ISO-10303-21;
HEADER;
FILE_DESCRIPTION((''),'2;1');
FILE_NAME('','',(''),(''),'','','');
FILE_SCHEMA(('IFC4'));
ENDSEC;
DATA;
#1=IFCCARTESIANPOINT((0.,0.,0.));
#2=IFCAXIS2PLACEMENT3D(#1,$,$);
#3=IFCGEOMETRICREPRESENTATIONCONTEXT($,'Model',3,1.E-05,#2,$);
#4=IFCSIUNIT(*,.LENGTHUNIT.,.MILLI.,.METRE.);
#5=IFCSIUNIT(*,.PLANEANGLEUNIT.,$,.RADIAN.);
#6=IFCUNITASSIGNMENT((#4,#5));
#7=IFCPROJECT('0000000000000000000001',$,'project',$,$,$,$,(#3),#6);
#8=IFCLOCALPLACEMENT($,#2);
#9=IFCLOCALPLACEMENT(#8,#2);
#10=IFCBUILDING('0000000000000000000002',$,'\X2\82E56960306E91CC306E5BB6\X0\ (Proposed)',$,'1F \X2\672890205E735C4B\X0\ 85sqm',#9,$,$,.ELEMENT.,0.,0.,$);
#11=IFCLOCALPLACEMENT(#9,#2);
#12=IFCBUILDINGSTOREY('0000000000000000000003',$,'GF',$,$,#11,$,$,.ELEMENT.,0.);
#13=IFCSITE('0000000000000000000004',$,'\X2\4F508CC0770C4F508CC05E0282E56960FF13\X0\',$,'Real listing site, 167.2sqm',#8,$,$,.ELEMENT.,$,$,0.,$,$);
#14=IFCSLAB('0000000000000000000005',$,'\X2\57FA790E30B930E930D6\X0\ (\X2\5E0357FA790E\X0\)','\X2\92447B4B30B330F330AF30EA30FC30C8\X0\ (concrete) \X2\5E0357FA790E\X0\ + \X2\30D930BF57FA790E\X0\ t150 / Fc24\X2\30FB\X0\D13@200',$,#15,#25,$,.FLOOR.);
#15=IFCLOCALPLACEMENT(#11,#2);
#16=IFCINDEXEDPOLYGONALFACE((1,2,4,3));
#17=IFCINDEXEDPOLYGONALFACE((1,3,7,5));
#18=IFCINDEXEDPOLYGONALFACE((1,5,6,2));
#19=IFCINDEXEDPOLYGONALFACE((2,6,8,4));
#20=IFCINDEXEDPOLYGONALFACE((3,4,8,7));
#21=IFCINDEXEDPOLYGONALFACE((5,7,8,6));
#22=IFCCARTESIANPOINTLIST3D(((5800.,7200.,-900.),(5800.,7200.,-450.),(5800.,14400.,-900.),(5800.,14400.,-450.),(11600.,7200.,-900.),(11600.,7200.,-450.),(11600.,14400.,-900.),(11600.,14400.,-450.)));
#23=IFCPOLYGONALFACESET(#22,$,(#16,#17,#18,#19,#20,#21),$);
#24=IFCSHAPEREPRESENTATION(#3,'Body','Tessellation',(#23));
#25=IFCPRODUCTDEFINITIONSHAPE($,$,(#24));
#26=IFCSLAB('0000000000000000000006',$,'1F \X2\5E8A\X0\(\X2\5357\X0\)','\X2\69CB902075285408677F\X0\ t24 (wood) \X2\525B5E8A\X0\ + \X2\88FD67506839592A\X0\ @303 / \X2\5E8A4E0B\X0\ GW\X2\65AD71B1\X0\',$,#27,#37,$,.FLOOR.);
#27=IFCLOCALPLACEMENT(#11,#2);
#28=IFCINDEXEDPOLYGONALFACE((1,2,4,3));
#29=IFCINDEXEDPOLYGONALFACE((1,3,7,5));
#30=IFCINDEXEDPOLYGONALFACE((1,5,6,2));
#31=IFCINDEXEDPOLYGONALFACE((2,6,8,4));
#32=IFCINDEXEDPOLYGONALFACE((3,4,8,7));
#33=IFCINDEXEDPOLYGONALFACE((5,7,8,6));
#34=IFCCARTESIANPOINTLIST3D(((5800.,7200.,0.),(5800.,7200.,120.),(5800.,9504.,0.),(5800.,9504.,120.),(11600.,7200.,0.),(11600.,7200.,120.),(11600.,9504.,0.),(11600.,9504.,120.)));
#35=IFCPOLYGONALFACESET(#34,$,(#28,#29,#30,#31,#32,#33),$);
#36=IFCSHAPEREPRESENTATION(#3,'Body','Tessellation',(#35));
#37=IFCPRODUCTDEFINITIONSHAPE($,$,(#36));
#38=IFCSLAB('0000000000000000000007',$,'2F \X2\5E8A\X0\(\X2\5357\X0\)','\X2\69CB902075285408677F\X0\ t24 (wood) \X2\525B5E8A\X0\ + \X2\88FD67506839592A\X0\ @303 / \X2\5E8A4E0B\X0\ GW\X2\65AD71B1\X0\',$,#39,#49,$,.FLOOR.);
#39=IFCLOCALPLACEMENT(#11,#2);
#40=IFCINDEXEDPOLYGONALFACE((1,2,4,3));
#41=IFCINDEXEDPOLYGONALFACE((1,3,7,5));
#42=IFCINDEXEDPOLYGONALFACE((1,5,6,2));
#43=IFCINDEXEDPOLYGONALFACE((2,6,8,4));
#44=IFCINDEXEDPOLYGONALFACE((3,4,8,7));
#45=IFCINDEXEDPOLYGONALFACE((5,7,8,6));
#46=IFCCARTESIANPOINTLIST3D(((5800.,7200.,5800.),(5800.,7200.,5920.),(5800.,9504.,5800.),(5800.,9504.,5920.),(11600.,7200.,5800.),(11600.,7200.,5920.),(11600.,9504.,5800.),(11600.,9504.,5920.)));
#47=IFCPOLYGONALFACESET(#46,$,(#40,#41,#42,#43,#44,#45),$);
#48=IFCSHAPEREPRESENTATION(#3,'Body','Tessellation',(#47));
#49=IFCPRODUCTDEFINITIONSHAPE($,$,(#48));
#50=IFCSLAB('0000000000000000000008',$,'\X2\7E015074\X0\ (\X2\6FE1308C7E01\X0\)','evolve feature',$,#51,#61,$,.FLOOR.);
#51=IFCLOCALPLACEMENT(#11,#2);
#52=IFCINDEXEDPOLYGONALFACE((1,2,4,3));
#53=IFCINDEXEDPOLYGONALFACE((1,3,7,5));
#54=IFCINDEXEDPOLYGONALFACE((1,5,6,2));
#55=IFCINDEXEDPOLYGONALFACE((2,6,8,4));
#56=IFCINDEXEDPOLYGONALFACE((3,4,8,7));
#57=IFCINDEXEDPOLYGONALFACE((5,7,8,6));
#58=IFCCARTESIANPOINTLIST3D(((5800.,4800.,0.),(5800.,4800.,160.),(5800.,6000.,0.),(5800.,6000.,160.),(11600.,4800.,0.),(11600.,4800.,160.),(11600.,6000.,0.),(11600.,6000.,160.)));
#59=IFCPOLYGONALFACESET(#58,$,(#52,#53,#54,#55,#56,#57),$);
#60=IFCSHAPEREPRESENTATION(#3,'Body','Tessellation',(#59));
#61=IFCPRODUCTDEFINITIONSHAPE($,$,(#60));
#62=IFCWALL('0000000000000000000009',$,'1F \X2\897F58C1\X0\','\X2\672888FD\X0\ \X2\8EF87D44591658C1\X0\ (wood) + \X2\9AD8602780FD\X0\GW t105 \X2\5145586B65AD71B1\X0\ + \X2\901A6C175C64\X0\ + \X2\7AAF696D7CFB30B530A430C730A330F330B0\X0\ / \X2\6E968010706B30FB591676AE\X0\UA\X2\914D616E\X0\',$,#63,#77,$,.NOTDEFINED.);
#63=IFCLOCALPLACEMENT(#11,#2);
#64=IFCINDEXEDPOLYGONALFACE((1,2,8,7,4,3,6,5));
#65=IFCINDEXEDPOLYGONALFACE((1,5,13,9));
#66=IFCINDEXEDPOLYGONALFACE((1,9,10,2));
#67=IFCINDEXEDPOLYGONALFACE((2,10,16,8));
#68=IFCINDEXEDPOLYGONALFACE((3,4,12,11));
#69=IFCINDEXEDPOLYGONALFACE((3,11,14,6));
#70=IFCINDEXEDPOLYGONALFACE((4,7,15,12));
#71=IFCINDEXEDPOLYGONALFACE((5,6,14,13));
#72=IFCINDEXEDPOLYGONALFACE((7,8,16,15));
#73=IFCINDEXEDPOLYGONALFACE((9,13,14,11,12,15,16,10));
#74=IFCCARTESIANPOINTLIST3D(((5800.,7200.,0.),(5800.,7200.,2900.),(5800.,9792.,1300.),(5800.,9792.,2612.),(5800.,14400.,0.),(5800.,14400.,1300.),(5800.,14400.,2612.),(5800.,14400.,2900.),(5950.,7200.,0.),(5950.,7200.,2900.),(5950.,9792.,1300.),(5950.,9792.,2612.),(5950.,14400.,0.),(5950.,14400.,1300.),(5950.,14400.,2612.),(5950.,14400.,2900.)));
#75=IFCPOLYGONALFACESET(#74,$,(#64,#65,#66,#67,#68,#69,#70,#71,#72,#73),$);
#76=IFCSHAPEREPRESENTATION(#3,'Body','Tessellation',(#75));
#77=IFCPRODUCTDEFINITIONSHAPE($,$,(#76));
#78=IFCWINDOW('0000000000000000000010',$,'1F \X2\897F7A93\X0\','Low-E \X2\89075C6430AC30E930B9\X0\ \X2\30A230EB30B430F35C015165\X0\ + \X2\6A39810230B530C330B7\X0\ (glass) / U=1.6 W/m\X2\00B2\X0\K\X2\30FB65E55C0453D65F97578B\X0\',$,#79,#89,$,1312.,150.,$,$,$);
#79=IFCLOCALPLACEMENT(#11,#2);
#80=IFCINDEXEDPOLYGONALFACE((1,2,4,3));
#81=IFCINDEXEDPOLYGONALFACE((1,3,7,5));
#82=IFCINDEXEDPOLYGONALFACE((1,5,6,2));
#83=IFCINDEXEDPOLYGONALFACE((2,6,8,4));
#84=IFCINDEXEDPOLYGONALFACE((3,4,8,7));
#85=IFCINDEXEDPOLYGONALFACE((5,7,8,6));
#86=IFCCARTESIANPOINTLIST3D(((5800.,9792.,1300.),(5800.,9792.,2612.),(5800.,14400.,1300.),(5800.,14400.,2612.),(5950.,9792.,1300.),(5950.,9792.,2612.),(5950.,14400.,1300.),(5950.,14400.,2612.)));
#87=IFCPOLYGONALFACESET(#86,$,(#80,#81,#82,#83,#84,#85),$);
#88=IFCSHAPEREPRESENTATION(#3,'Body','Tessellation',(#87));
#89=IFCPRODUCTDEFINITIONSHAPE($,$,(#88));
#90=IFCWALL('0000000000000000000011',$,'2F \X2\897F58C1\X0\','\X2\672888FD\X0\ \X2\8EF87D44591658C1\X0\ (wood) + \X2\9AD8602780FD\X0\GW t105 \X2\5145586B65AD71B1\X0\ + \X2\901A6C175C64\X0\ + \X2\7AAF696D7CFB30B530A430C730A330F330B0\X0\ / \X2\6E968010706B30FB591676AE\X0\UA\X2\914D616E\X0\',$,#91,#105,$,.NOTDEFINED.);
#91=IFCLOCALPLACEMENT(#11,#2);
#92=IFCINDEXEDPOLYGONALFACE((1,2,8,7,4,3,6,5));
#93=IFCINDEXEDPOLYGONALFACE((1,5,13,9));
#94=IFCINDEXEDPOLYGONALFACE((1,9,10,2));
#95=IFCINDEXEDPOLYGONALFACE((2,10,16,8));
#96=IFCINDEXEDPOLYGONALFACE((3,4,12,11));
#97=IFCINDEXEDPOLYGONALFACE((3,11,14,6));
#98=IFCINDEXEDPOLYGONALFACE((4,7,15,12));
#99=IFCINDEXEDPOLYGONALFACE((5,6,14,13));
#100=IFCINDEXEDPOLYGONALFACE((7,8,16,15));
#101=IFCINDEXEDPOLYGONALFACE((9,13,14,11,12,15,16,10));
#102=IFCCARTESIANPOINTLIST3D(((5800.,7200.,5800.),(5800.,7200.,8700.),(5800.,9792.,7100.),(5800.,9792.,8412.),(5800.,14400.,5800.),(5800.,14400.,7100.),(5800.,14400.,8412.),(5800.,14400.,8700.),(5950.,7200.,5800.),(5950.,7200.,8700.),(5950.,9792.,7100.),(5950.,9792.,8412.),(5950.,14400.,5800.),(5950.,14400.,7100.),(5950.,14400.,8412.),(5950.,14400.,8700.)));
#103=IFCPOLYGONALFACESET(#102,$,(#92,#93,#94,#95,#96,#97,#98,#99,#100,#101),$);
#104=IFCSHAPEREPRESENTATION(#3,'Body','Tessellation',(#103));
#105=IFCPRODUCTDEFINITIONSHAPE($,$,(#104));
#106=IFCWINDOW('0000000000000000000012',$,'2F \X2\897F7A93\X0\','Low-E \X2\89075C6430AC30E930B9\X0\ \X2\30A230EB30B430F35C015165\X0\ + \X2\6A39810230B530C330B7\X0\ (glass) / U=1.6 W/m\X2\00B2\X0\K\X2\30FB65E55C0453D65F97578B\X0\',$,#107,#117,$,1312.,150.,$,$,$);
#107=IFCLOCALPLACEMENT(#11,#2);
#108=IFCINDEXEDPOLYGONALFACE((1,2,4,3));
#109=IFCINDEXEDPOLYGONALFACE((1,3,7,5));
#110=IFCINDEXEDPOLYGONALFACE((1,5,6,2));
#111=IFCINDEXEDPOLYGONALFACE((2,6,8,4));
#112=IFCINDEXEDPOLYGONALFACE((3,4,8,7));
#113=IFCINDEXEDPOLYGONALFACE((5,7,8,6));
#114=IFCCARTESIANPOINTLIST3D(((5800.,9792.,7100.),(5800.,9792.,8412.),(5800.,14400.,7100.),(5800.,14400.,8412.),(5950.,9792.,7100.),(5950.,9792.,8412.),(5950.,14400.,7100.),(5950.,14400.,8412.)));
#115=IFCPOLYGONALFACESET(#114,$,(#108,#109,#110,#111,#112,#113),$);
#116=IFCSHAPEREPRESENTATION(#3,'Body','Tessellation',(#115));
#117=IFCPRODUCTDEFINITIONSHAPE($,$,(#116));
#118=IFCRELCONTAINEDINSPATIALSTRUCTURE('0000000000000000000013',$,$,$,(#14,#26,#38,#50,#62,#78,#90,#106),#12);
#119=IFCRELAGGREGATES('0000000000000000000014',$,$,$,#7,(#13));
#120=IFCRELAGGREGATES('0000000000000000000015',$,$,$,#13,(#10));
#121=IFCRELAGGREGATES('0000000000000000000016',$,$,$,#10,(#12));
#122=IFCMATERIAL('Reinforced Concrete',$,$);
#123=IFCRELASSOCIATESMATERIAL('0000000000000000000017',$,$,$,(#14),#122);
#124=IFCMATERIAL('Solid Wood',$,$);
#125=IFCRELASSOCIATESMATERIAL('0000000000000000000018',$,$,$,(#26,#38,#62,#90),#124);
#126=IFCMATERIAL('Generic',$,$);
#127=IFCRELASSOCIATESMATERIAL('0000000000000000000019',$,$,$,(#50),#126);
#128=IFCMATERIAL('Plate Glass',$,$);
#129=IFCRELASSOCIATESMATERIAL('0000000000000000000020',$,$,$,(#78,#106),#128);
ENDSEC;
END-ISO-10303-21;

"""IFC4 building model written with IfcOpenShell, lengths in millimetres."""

from ifc_helpers import new_model, si_unit, frame, frame_2d, origin, place, context, project, spatial, rectangle, extrude, material, element, fill, save


model = new_model("IFC4")

# Units and contexts
model_context = context("Model", 3, precision=1e-05, world=origin())
ifc_project = project(units=[si_unit("LENGTHUNIT", "METRE", prefix="MILLI"), si_unit("PLANEANGLEUNIT", "RADIAN")], contexts=[model_context])

# Site, building, storey
site_placement = place(None, origin())
site = spatial("IfcSite", under=ifc_project, at=site_placement, Name="佐賀県佐賀市若楠３", ObjectType="Real listing site, 167.2sqm", CompositionType="ELEMENT", RefElevation=0.0)
building_placement = place(site_placement, origin())
building = spatial("IfcBuilding", under=site, at=building_placement, Name="若楠の里の家 (Proposed)", ObjectType="1F 木造平屋 85sqm", CompositionType="ELEMENT", ElevationOfRefHeight=0.0, ElevationOfTerrain=0.0)
storey_placement = place(building_placement, origin())
storey = spatial("IfcBuildingStorey", under=building, at=storey_placement, Name="GF", CompositionType="ELEMENT", Elevation=0.0)

# Slabs
ifc_material_1 = material(Name="Reinforced Concrete")
slab_1_placement = place(storey_placement, frame((2900.0, 3600.0, -450.0)))
element("IfcSlab", 1, at=slab_1_placement, inside=storey, material=ifc_material_1, Name="基礎スラブ (布基礎)", Description="鉄筋コンクリート (concrete) 布基礎 + ベタ基礎 t150 / Fc24・D13@200", PredefinedType="FLOOR", context=model_context, shape_type="SweptSolid", body=[
    extrude(rectangle(XDim=5800.0, YDim=7200.0, at=frame_2d((2900.0, 3600.0))), frame((2900.0, 3600.0, -450.0)), (0.0, 0.0, 1.0), 450.0),
])
ifc_material_2 = material(Name="Solid Wood")
slab_2_placement = place(storey_placement, frame((2900.0, 3600.0, 0.0)))
element("IfcSlab", 2, at=slab_2_placement, inside=storey, material=ifc_material_2, Name="1F 床(南)", Description="構造用合板 t24 (wood) 剛床 + 製材根太 @303 / 床下 GW断熱", PredefinedType="FLOOR", context=model_context, shape_type="SweptSolid", body=[
    extrude(rectangle(XDim=5800.0, YDim=2304.0, at=frame_2d((2900.0, 1152.0))), frame((2900.0, 3600.0, 0.0)), (0.0, 0.0, 1.0), 120.0),
])
slab_3_placement = place(storey_placement, frame((2900.0, 3600.0, 2900.0)))
element("IfcSlab", 3, at=slab_3_placement, inside=storey, material=ifc_material_2, Name="2F 床(南)", Description="構造用合板 t24 (wood) 剛床 + 製材根太 @303 / 床下 GW断熱", PredefinedType="FLOOR", context=model_context, shape_type="SweptSolid", body=[
    extrude(rectangle(XDim=5800.0, YDim=2304.0, at=frame_2d((2900.0, 1152.0))), frame((2900.0, 3600.0, 2900.0)), (0.0, 0.0, 1.0), 120.0),
])
ifc_material_3 = material(Name="Generic")
slab_4_placement = place(storey_placement, frame((2900.0, 2400.0, 0.0)))
element("IfcSlab", 4, at=slab_4_placement, inside=storey, material=ifc_material_3, Name="縁側 (濡れ縁)", Description="evolve feature", PredefinedType="FLOOR", context=model_context, shape_type="SweptSolid", body=[
    extrude(rectangle(XDim=5800.0, YDim=1200.0, at=frame_2d((2900.0, 600.0))), frame((2900.0, 2400.0, 0.0)), (0.0, 0.0, 1.0), 160.0),
])

# Shared definitions
ifc_material_4 = material(Name="Plate Glass")

# Walls, openings, windows
wall_1_placement = place(storey_placement, frame((2900.0, 3600.0, 0.0)))
wall_1 = element("IfcWall", 5, at=wall_1_placement, inside=storey, material=ifc_material_2, Name="1F 西壁", Description="木製 軸組外壁 (wood) + 高性能GW t105 充填断熱 + 通気層 + 窯業系サイディング / 準耐火・外皮UA配慮", PredefinedType="NOTDEFINED", context=model_context, shape_type="SweptSolid", body=[
    extrude(rectangle(XDim=150.0, YDim=7200.0, at=frame_2d((75.0, 3600.0))), frame((2900.0, 3600.0, 0.0)), (0.0, 0.0, 1.0), 2900.0),
])
opening_1_placement = place(storey_placement, frame((2900.0, 4896.0, 650.0)))
opening_1 = element("IfcOpeningElement", 6, at=opening_1_placement, cuts=wall_1, PredefinedType="NOTDEFINED", context=model_context, shape_type="SweptSolid", body=[
    extrude(rectangle(XDim=150.0, YDim=4608.0, at=frame_2d((75.0, 2304.0))), frame((2900.0, 4896.0, 650.0)), (0.0, 0.0, 1.0), 1312.0),
])
window_1_placement = place(storey_placement, frame((2900.0, 4896.0, 650.0)))
window_1 = element("IfcWindow", 7, at=window_1_placement, inside=storey, material=ifc_material_4, Name="1F 西窓", Description="Low-E 複層ガラス アルゴン封入 + 樹脂サッシ (glass) / U=1.6 W/m²K・日射取得型", OverallHeight=1312.0, OverallWidth=150.0, context=model_context, shape_type="SweptSolid", body=[
    extrude(rectangle(XDim=150.0, YDim=4608.0, at=frame_2d((75.0, 2304.0))), frame((2900.0, 4896.0, 650.0)), (0.0, 0.0, 1.0), 1312.0),
])
fill(opening_1, window_1)
wall_2_placement = place(storey_placement, frame((2900.0, 3600.0, 2900.0)))
wall_2 = element("IfcWall", 8, at=wall_2_placement, inside=storey, material=ifc_material_2, Name="2F 西壁", Description="木製 軸組外壁 (wood) + 高性能GW t105 充填断熱 + 通気層 + 窯業系サイディング / 準耐火・外皮UA配慮", PredefinedType="NOTDEFINED", context=model_context, shape_type="SweptSolid", body=[
    extrude(rectangle(XDim=150.0, YDim=7200.0, at=frame_2d((75.0, 3600.0))), frame((2900.0, 3600.0, 2900.0)), (0.0, 0.0, 1.0), 2900.0),
])
opening_2_placement = place(storey_placement, frame((2900.0, 4896.0, 3550.0)))
opening_2 = element("IfcOpeningElement", 9, at=opening_2_placement, cuts=wall_2, PredefinedType="NOTDEFINED", context=model_context, shape_type="SweptSolid", body=[
    extrude(rectangle(XDim=150.0, YDim=4608.0, at=frame_2d((75.0, 2304.0))), frame((2900.0, 4896.0, 3550.0)), (0.0, 0.0, 1.0), 1312.0),
])
window_2_placement = place(storey_placement, frame((2900.0, 4896.0, 3550.0)))
window_2 = element("IfcWindow", 10, at=window_2_placement, inside=storey, material=ifc_material_4, Name="2F 西窓", Description="Low-E 複層ガラス アルゴン封入 + 樹脂サッシ (glass) / U=1.6 W/m²K・日射取得型", OverallHeight=1312.0, OverallWidth=150.0, context=model_context, shape_type="SweptSolid", body=[
    extrude(rectangle(XDim=150.0, YDim=4608.0, at=frame_2d((75.0, 2304.0))), frame((2900.0, 4896.0, 3550.0)), (0.0, 0.0, 1.0), 1312.0),
])
fill(opening_2, window_2)

save(model, "model.ifc")
